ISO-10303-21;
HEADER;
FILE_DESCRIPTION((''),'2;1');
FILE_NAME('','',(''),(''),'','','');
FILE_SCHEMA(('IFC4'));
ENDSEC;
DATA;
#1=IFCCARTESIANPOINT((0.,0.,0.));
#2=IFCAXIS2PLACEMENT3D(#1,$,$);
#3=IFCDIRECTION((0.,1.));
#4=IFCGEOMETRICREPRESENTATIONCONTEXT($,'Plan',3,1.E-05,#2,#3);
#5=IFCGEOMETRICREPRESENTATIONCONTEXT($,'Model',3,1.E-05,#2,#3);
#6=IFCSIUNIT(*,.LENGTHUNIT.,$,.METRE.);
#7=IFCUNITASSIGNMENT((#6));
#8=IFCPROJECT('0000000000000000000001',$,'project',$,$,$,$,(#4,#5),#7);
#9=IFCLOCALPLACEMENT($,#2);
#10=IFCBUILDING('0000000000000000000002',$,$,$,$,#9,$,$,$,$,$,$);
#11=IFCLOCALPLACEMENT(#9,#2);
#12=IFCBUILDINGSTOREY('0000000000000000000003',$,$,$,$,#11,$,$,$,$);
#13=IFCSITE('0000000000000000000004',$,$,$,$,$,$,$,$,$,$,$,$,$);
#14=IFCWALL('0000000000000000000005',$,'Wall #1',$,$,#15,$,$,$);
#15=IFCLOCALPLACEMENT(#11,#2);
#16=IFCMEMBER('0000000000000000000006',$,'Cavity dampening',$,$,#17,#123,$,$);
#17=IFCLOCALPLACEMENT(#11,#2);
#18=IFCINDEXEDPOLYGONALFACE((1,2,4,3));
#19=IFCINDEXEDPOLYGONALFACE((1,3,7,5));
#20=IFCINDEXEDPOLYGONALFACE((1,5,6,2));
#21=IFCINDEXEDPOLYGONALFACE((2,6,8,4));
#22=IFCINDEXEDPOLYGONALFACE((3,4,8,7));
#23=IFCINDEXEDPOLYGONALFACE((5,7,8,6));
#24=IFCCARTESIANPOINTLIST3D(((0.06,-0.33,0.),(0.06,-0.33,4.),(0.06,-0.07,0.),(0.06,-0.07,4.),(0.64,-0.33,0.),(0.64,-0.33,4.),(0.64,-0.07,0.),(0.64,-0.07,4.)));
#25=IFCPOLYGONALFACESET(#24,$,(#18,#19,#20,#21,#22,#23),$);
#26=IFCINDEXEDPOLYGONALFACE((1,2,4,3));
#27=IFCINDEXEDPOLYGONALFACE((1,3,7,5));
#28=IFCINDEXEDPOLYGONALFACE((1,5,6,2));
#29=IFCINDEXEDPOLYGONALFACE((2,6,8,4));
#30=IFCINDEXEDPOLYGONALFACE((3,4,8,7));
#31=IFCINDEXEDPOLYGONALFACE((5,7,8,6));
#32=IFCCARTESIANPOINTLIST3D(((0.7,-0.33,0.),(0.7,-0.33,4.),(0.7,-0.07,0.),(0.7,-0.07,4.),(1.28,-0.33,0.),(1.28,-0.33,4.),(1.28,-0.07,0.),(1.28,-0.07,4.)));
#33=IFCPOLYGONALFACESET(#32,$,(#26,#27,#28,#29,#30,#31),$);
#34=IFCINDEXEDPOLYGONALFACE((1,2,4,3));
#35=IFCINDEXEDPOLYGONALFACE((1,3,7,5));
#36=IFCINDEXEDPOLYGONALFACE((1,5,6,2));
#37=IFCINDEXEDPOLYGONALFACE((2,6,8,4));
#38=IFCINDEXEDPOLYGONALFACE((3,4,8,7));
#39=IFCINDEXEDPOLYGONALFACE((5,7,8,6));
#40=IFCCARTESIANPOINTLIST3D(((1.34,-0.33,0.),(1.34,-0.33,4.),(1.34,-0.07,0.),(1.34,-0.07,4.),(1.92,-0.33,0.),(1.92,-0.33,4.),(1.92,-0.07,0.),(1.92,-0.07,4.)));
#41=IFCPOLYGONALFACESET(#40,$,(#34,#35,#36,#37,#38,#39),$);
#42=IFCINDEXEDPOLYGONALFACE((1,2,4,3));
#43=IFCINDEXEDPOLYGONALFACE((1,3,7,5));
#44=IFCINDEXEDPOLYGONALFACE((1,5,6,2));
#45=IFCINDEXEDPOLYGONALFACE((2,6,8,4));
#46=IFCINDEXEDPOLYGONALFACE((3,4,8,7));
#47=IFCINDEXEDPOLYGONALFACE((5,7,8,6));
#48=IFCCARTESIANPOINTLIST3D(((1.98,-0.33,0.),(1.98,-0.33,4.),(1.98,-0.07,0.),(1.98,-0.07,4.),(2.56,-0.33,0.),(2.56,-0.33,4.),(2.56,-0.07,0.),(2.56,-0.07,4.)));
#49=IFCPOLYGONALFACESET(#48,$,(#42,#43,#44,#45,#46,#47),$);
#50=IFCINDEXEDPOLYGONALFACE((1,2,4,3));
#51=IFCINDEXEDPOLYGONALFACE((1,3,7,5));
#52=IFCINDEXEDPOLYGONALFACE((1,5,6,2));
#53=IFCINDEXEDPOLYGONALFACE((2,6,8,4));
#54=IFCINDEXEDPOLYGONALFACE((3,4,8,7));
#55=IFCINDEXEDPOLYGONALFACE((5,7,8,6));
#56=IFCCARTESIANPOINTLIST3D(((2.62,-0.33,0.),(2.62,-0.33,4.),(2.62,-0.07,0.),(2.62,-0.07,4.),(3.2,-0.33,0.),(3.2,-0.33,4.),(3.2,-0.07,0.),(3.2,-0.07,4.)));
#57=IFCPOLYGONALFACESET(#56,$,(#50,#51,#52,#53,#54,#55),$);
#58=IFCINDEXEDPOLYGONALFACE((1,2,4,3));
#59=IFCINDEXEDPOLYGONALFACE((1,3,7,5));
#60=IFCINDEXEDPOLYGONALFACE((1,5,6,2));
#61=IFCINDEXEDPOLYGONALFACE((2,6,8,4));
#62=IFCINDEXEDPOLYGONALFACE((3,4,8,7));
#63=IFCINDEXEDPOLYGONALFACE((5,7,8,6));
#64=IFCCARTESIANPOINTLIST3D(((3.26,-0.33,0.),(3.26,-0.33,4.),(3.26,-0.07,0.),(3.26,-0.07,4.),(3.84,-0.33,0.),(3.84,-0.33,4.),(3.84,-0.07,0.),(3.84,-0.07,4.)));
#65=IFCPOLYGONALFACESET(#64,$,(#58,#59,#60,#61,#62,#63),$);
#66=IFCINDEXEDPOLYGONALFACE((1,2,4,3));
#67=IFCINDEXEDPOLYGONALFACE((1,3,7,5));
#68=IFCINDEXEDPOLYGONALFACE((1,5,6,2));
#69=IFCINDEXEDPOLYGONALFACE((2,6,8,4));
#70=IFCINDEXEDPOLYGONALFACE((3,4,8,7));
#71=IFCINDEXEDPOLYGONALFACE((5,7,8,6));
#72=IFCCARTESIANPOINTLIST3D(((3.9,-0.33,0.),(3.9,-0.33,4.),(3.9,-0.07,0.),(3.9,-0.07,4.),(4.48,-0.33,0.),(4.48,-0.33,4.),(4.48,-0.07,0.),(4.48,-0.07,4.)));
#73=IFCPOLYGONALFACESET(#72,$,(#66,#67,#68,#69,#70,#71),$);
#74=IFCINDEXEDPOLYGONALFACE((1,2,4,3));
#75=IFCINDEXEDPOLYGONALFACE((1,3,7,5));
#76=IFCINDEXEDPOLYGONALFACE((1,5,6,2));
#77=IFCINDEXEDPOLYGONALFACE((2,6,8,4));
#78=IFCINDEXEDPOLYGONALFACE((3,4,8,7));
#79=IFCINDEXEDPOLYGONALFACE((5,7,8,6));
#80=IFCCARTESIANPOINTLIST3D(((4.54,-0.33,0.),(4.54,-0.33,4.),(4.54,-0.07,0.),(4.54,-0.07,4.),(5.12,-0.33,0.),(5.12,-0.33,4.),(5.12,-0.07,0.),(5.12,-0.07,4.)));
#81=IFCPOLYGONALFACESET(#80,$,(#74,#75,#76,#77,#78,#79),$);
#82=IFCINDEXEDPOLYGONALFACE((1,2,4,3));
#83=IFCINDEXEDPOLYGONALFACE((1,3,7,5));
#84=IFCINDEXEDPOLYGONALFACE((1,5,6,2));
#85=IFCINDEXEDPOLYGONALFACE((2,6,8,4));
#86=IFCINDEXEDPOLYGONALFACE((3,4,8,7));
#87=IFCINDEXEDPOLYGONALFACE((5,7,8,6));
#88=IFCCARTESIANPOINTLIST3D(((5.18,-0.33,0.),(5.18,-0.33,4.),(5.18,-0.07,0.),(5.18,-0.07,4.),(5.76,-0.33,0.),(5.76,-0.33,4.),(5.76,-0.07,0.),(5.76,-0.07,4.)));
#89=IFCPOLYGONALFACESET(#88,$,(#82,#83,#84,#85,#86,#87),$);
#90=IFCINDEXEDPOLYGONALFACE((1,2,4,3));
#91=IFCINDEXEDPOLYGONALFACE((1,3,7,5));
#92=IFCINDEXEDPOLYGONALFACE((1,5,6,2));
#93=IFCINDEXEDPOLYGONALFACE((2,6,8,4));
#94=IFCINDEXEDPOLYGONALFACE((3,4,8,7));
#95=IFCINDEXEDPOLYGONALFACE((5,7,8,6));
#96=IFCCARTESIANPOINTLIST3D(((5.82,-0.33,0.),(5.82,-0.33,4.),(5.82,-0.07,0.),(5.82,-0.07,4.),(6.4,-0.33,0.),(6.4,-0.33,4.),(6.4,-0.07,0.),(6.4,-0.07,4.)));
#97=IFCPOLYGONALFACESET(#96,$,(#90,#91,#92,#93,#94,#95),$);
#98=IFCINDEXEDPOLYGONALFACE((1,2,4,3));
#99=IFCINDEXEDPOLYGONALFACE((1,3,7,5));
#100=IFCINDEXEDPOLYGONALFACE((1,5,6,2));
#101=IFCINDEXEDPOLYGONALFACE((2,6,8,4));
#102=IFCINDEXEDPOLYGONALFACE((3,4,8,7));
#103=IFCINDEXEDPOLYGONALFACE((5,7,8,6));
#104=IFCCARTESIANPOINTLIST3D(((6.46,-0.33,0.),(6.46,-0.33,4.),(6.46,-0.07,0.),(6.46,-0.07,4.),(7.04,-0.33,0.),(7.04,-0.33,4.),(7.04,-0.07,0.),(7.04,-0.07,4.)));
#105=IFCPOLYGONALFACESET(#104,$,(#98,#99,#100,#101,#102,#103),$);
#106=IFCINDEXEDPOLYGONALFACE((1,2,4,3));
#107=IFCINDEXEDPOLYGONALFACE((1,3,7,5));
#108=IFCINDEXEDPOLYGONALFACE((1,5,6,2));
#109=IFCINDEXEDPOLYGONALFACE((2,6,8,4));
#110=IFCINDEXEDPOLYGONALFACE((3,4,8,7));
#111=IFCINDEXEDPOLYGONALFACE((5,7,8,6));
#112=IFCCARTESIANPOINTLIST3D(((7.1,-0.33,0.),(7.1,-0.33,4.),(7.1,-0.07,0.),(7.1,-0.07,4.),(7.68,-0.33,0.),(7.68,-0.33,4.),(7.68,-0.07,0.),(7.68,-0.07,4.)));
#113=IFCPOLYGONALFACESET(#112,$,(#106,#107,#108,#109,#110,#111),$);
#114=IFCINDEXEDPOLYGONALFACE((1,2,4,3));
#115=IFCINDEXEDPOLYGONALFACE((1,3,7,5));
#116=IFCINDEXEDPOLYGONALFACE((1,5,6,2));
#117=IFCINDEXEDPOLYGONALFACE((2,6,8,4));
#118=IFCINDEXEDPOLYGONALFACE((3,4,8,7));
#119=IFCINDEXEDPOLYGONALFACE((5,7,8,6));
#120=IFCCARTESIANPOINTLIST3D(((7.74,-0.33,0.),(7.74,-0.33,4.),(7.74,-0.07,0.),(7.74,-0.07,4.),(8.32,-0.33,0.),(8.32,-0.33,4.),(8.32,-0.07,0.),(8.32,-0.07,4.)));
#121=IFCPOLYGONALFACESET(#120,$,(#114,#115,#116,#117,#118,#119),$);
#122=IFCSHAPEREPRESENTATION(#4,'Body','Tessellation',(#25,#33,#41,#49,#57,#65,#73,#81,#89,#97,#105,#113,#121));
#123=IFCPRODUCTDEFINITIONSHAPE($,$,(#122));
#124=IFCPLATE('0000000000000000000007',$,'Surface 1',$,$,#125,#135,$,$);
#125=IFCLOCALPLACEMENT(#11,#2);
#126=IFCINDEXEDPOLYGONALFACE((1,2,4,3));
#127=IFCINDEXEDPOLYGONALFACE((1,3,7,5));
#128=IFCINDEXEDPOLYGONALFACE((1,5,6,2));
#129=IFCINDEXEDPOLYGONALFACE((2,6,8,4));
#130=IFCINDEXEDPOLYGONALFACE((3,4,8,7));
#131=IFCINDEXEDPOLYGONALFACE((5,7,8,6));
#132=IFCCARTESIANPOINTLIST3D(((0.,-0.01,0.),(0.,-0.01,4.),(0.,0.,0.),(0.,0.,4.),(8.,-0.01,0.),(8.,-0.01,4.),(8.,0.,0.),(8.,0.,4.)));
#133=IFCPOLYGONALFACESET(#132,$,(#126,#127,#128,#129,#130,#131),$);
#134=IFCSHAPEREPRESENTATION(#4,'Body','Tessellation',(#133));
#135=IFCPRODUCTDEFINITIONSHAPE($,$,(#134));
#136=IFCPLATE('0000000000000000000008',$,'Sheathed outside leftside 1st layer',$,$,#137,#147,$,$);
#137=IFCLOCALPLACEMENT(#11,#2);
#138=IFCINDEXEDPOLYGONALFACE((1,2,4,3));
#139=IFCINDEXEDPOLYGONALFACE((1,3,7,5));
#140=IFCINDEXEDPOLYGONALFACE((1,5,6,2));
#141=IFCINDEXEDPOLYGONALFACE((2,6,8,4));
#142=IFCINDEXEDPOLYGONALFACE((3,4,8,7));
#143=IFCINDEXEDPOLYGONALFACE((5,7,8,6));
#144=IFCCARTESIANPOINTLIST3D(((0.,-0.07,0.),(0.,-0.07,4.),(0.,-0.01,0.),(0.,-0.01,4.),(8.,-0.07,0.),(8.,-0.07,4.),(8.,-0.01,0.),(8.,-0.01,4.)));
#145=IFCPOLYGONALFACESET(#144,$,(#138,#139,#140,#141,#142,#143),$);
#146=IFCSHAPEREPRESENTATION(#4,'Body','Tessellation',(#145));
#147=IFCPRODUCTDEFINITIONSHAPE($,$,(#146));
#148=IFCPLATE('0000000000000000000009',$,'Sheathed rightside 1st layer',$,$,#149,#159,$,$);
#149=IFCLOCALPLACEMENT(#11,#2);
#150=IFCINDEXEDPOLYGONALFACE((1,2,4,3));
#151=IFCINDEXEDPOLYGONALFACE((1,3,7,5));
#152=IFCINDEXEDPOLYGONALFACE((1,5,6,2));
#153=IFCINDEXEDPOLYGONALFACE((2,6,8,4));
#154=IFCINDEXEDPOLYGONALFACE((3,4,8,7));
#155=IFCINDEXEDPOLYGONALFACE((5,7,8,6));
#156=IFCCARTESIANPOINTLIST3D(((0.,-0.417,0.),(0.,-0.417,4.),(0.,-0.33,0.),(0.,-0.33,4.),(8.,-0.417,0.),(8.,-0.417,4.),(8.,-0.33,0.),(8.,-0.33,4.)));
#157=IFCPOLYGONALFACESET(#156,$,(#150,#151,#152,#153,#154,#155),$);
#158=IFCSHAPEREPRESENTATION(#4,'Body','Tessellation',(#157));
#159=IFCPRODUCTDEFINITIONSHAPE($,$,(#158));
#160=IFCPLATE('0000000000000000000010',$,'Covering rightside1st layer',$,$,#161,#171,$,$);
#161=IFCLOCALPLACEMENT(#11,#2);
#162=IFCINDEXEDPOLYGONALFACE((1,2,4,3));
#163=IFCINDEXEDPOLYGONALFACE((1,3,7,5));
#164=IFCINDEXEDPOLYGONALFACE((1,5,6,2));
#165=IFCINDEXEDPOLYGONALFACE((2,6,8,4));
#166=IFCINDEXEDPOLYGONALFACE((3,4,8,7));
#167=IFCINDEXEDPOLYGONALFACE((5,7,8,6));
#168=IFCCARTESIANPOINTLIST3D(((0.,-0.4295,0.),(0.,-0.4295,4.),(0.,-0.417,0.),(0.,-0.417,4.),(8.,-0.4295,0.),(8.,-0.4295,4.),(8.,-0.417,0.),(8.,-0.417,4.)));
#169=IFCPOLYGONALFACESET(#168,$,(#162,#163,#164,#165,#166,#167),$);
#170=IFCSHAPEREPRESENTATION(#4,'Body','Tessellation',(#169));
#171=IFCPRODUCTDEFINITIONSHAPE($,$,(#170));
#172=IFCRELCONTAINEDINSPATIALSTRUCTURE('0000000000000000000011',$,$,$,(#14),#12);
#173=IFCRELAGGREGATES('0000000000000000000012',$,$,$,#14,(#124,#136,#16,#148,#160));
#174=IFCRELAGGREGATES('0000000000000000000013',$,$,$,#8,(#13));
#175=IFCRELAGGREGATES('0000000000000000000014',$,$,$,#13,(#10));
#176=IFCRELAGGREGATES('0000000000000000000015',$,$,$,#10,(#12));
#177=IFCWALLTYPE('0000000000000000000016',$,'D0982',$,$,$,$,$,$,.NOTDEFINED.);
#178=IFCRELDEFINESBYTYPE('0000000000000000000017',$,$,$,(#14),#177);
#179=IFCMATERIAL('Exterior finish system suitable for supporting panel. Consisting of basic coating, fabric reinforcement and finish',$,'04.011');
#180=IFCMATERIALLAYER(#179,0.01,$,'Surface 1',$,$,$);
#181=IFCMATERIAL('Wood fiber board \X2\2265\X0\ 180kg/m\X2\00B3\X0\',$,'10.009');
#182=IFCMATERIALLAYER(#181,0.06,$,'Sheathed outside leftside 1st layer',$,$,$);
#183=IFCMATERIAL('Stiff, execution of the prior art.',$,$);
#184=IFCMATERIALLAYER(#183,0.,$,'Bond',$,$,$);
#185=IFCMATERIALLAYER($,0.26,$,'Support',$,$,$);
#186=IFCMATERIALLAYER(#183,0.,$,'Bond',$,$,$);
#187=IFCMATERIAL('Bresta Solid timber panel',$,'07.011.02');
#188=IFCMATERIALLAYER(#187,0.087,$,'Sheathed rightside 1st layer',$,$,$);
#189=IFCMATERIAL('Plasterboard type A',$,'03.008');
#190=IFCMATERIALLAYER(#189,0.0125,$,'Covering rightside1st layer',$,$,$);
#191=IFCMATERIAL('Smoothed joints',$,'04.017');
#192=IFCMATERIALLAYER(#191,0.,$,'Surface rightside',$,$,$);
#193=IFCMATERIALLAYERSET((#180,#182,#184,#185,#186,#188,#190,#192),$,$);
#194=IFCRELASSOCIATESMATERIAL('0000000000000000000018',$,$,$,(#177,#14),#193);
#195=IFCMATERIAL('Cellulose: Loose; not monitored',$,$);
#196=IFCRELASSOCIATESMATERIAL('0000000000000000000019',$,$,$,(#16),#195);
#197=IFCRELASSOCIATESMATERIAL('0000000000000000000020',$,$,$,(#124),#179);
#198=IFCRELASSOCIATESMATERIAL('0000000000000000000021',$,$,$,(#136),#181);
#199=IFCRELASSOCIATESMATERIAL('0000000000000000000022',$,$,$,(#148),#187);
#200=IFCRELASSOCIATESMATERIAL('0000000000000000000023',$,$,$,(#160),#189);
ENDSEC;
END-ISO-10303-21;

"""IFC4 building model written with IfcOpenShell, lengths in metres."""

from ifc_helpers import new_model, si_unit, direction, frame, frame_2d, origin, origin_with_axes, place, context, project, spatial, rectangle, extrude, material, layer, layer_set, type_object, element, aggregate, save


model = new_model("IFC4")

# Units and contexts
plan_context = context("Plan", 3, precision=1e-05, world=origin(), true_north=direction((0.0, 1.0)))
model_context = context("Model", 3, precision=1e-05, world=origin(), true_north=direction((0.0, 1.0)))
ifc_project = project(units=[si_unit("LENGTHUNIT", "METRE")], contexts=[plan_context, model_context])

# Site, building, storey
site = spatial("IfcSite", under=ifc_project)
building_placement = place(None, origin())
building = spatial("IfcBuilding", under=site, at=building_placement)
storey_placement = place(building_placement, origin())
storey = spatial("IfcBuildingStorey", under=building, at=storey_placement)

# Wall, member, plates
ifc_material_1 = material(Name="Exterior finish system suitable for supporting panel. Consisting of basic coating, fabric reinforcement and finish", Category="04.011")
ifc_layer_1 = layer(ifc_material_1, 0.01, Name="Surface 1")
ifc_material_2 = material(Name="Wood fiber board ≥ 180kg/m³", Category="10.009")
ifc_layer_2 = layer(ifc_material_2, 0.06, Name="Sheathed outside leftside 1st layer")
ifc_material_3 = material(Name="Stiff, execution of the prior art.")
ifc_layer_3 = layer(ifc_material_3, 0.0, Name="Bond")
ifc_layer_4 = layer(None, 0.26, Name="Support")
ifc_layer_5 = layer(ifc_material_3, 0.0, Name="Bond")
ifc_material_4 = material(Name="Bresta Solid timber panel", Category="07.011.02")
ifc_layer_6 = layer(ifc_material_4, 0.087, Name="Sheathed rightside 1st layer")
ifc_material_5 = material(Name="Plasterboard type A", Category="03.008")
ifc_layer_7 = layer(ifc_material_5, 0.0125, Name="Covering rightside1st layer")
ifc_material_6 = material(Name="Smoothed joints", Category="04.017")
ifc_layer_8 = layer(ifc_material_6, 0.0, Name="Surface rightside")
ifc_layer_set = layer_set([ifc_layer_1, ifc_layer_2, ifc_layer_3, ifc_layer_4, ifc_layer_5, ifc_layer_6, ifc_layer_7, ifc_layer_8])
wall_type = type_object("IfcWallType", Name="D0982", PredefinedType="NOTDEFINED", material=ifc_layer_set)
wall_placement = place(None, frame((0.0, 0.0, 0.0), z_axis=(0.0, -1.0, 0.0), x_axis=(1.0, 0.0, 0.0)))
wall = element("IfcWall", 1, at=wall_placement, inside=storey, type_object=wall_type, material=ifc_layer_set, Name="Wall #1")
ifc_material_7 = material(Name="Cellulose: Loose; not monitored")
member_1_placement = place(wall_placement, origin())
member_1 = element("IfcMember", 2, at=member_1_placement, material=ifc_material_7, Name="Cavity dampening", context=plan_context, shape_type="SweptSolid", body=[
    extrude(rectangle(XDim=0.58, YDim=0.26, at=frame_2d((0.29, 0.13), x_axis=(1.0, 0.0))), frame((0.06, 4.0, 0.07), z_axis=(0.0, -1.0, 0.0), x_axis=(1.0, 0.0, 0.0)), (0.0, 0.0, 1.0), 4.0),
    extrude(rectangle(XDim=0.58, YDim=0.26, at=frame_2d((0.29, 0.13), x_axis=(1.0, 0.0))), frame((0.7, 4.0, 0.07), z_axis=(0.0, -1.0, 0.0), x_axis=(1.0, 0.0, 0.0)), (0.0, 0.0, 1.0), 4.0),
    extrude(rectangle(XDim=0.58, YDim=0.26, at=frame_2d((0.29, 0.13), x_axis=(1.0, 0.0))), frame((1.34, 4.0, 0.07), z_axis=(0.0, -1.0, 0.0), x_axis=(1.0, 0.0, 0.0)), (0.0, 0.0, 1.0), 4.0),
    extrude(rectangle(XDim=0.58, YDim=0.26, at=frame_2d((0.29, 0.13), x_axis=(1.0, 0.0))), frame((1.98, 4.0, 0.07), z_axis=(0.0, -1.0, 0.0), x_axis=(1.0, 0.0, 0.0)), (0.0, 0.0, 1.0), 4.0),
    extrude(rectangle(XDim=0.58, YDim=0.26, at=frame_2d((0.29, 0.13), x_axis=(1.0, 0.0))), frame((2.62, 4.0, 0.07), z_axis=(0.0, -1.0, 0.0), x_axis=(1.0, 0.0, 0.0)), (0.0, 0.0, 1.0), 4.0),
    extrude(rectangle(XDim=0.58, YDim=0.26, at=frame_2d((0.29, 0.13), x_axis=(1.0, 0.0))), frame((3.26, 4.0, 0.07), z_axis=(0.0, -1.0, 0.0), x_axis=(1.0, 0.0, 0.0)), (0.0, 0.0, 1.0), 4.0),
    extrude(rectangle(XDim=0.58, YDim=0.26, at=frame_2d((0.29, 0.13), x_axis=(1.0, 0.0))), frame((3.9, 4.0, 0.07), z_axis=(0.0, -1.0, 0.0), x_axis=(1.0, 0.0, 0.0)), (0.0, 0.0, 1.0), 4.0),
    extrude(rectangle(XDim=0.58, YDim=0.26, at=frame_2d((0.29, 0.13), x_axis=(1.0, 0.0))), frame((4.54, 4.0, 0.07), z_axis=(0.0, -1.0, 0.0), x_axis=(1.0, 0.0, 0.0)), (0.0, 0.0, 1.0), 4.0),
    extrude(rectangle(XDim=0.58, YDim=0.26, at=frame_2d((0.29, 0.13), x_axis=(1.0, 0.0))), frame((5.18, 4.0, 0.07), z_axis=(0.0, -1.0, 0.0), x_axis=(1.0, 0.0, 0.0)), (0.0, 0.0, 1.0), 4.0),
    extrude(rectangle(XDim=0.58, YDim=0.26, at=frame_2d((0.29, 0.13), x_axis=(1.0, 0.0))), frame((5.82, 4.0, 0.07), z_axis=(0.0, -1.0, 0.0), x_axis=(1.0, 0.0, 0.0)), (0.0, 0.0, 1.0), 4.0),
    extrude(rectangle(XDim=0.58, YDim=0.26, at=frame_2d((0.29, 0.13), x_axis=(1.0, 0.0))), frame((6.46, 4.0, 0.07), z_axis=(0.0, -1.0, 0.0), x_axis=(1.0, 0.0, 0.0)), (0.0, 0.0, 1.0), 4.0),
    extrude(rectangle(XDim=0.58, YDim=0.26, at=frame_2d((0.29, 0.13), x_axis=(1.0, 0.0))), frame((7.1, 4.0, 0.07), z_axis=(0.0, -1.0, 0.0), x_axis=(1.0, 0.0, 0.0)), (0.0, 0.0, 1.0), 4.0),
    extrude(rectangle(XDim=0.58, YDim=0.26, at=frame_2d((0.29, 0.13), x_axis=(1.0, 0.0))), frame((7.74, 4.0, 0.07), z_axis=(0.0, -1.0, 0.0), x_axis=(1.0, 0.0, 0.0)), (0.0, 0.0, 1.0), 4.0),
])
plate_1_placement = place(wall_placement, origin())
plate_1 = element("IfcPlate", 3, at=plate_1_placement, material=ifc_material_1, Name="Surface 1", context=plan_context, shape_type="SweptSolid", body=[
    extrude(rectangle(XDim=8.0, YDim=4.0, at=frame_2d((4.0, 2.0), x_axis=(1.0, 0.0))), origin_with_axes(), (0.0, 0.0, 1.0), 0.01),
])
plate_2_placement = place(wall_placement, origin())
plate_2 = element("IfcPlate", 4, at=plate_2_placement, material=ifc_material_2, Name="Sheathed outside leftside 1st layer", context=plan_context, shape_type="SweptSolid", body=[
    extrude(rectangle(XDim=8.0, YDim=4.0, at=frame_2d((4.0, 2.0), x_axis=(1.0, 0.0))), frame((0.0, 0.0, 0.01), z_axis=(0.0, 0.0, 1.0), x_axis=(1.0, 0.0, 0.0)), (0.0, 0.0, 1.0), 0.06),
])
plate_3_placement = place(wall_placement, origin())
plate_3 = element("IfcPlate", 5, at=plate_3_placement, material=ifc_material_4, Name="Sheathed rightside 1st layer", context=plan_context, shape_type="SweptSolid", body=[
    extrude(rectangle(XDim=8.0, YDim=4.0, at=frame_2d((4.0, 2.0), x_axis=(1.0, 0.0))), frame((0.0, 0.0, 0.33), z_axis=(0.0, 0.0, 1.0), x_axis=(1.0, 0.0, 0.0)), (0.0, 0.0, 1.0), 0.087),
])
plate_4_placement = place(wall_placement, origin())
plate_4 = element("IfcPlate", 6, at=plate_4_placement, material=ifc_material_5, Name="Covering rightside1st layer", context=plan_context, shape_type="SweptSolid", body=[
    extrude(rectangle(XDim=8.0, YDim=4.0, at=frame_2d((4.0, 2.0), x_axis=(1.0, 0.0))), frame((0.0, 0.0, 0.417), z_axis=(0.0, 0.0, 1.0), x_axis=(1.0, 0.0, 0.0)), (0.0, 0.0, 1.0), 0.0125),
])
aggregate(wall, [plate_1, plate_2, member_1, plate_3, plate_4])

save(model, "model.ifc")
